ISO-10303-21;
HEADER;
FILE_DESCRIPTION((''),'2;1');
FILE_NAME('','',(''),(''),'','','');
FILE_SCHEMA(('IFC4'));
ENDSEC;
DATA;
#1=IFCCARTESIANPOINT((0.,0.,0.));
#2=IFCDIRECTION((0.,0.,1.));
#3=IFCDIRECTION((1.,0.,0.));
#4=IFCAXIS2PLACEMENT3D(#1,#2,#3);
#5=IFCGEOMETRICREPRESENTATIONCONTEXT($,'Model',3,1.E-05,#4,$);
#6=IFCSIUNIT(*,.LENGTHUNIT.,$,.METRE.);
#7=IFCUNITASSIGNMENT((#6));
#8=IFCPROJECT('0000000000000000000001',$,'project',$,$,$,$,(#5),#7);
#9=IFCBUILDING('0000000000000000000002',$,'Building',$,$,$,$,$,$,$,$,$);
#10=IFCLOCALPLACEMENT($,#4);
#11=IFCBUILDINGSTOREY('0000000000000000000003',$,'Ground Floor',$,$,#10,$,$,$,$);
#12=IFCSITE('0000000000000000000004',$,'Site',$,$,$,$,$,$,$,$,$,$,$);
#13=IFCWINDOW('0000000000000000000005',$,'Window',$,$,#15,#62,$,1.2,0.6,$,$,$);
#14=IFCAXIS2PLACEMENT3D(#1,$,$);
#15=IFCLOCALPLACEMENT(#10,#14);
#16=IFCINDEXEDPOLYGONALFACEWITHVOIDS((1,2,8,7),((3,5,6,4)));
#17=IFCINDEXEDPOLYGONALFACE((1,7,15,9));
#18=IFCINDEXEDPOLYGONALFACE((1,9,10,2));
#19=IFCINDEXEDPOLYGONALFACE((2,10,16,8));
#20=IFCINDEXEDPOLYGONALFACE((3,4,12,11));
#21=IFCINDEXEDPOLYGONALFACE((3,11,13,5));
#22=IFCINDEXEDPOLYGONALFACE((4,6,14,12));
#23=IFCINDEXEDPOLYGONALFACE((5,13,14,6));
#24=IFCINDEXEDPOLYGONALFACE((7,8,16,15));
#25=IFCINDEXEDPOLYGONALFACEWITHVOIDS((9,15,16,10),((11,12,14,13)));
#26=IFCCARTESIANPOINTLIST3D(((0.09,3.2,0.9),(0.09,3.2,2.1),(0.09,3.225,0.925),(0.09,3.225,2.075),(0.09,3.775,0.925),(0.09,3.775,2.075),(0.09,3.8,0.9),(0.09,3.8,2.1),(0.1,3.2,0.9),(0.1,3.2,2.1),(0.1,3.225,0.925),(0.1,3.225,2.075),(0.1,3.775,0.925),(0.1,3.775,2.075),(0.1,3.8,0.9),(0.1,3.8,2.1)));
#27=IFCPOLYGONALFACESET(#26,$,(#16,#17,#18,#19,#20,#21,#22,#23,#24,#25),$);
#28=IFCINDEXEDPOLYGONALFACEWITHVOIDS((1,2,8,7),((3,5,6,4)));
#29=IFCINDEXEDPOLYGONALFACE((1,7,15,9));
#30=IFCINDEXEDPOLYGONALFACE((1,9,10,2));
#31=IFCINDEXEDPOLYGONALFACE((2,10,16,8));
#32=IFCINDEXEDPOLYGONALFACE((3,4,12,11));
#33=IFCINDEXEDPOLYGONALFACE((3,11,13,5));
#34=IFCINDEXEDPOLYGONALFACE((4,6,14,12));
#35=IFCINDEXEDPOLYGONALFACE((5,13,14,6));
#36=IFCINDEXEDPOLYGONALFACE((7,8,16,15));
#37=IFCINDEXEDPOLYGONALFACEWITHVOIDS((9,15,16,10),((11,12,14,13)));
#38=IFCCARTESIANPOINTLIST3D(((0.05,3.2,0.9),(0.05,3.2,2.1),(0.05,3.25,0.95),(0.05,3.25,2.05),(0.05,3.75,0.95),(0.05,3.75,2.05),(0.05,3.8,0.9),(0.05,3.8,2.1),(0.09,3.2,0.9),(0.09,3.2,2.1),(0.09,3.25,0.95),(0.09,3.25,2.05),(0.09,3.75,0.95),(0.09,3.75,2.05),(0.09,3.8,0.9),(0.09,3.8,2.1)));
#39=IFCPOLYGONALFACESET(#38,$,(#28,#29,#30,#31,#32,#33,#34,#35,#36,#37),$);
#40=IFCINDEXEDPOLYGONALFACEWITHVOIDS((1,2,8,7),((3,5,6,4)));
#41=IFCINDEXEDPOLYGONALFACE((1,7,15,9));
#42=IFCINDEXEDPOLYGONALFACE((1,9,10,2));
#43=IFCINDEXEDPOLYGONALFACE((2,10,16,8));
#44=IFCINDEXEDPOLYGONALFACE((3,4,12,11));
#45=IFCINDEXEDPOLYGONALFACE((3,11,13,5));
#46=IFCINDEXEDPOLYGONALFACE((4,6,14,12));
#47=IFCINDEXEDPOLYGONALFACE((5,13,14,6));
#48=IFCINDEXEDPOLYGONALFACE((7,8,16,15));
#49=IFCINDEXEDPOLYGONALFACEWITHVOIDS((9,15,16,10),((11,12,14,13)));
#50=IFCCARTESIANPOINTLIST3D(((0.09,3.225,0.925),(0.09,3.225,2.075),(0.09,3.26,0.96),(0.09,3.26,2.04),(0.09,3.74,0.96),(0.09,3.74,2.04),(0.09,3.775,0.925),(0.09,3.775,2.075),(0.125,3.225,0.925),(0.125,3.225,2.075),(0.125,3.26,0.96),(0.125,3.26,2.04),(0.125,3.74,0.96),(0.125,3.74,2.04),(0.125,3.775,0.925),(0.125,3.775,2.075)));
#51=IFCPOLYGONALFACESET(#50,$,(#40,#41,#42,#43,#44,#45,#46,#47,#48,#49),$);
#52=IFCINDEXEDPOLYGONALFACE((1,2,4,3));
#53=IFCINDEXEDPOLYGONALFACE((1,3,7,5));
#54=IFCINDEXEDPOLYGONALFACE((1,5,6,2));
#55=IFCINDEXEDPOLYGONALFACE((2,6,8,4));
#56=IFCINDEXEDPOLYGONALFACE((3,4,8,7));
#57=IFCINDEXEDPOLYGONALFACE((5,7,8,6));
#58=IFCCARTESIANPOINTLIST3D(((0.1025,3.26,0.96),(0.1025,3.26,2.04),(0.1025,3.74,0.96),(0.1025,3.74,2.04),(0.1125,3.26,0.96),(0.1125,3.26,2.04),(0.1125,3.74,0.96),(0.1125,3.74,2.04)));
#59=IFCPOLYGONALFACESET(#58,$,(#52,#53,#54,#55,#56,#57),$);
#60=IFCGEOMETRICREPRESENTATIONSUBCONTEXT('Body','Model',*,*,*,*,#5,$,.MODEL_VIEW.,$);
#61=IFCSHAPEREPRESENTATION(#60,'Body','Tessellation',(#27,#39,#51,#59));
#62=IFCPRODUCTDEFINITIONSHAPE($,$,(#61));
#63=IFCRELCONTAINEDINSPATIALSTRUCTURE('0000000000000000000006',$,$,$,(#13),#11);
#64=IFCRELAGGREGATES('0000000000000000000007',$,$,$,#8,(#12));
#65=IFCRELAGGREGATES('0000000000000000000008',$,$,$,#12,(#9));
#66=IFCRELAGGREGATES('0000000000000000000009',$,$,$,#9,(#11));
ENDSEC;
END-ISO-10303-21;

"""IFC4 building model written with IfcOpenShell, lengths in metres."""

from ifc_helpers import new_model, si_unit, frame, origin_with_axes, place, context, subcontext, project, spatial, line, indexed_curve, outline, extrude, element, save


model = new_model("IFC4")

# Units and contexts
model_context = context("Model", 3, precision=1e-05, world=origin_with_axes())
body_context = subcontext(model_context, "Body", "Model", "MODEL_VIEW")
ifc_project = project(units=[si_unit("LENGTHUNIT", "METRE")], contexts=[model_context])

# Site, building, storey
site = spatial("IfcSite", under=ifc_project, Name="Site")
building = spatial("IfcBuilding", under=site, Name="Building")
storey_placement = place(None, origin_with_axes())
storey = spatial("IfcBuildingStorey", under=building, at=storey_placement, Name="Ground Floor")

# Window
window_1_placement = place(storey_placement, frame((0.0, 3.8, 0.9), z_axis=(0.0, 0.0, 1.0), x_axis=(0.0, -1.0, 0.0)))
element("IfcWindow", 1, at=window_1_placement, inside=storey, Name="Window", OverallHeight=1.2, OverallWidth=0.6, context=body_context, shape_type="SweptSolid", body=[
    extrude(outline(indexed_curve([(0.0, 0.0), (0.6, 0.0), (0.6, 1.2), (0.0, 1.2)], segments=[line(1, 2, 3, 4, 1)]), holes=[indexed_curve([(0.025, 0.025), (0.575, 0.025), (0.575, 1.175), (0.025, 1.175)], segments=[line(1, 2, 3, 4, 1)])]), frame((0.0, 0.09, 0.0), z_axis=(0.0, -1.0, 0.0), x_axis=(1.0, 0.0, 0.0)), (0.0, 0.0, -1.0), 0.01),
    extrude(outline(indexed_curve([(0.0, 0.0), (0.6, 0.0), (0.6, 1.2), (0.0, 1.2)], segments=[line(1, 2, 3, 4, 1)]), holes=[indexed_curve([(0.05, 0.05), (0.55, 0.05), (0.55, 1.15), (0.05, 1.15)], segments=[line(1, 2, 3, 4, 1)])]), frame((0.0, 0.05, 0.0), z_axis=(0.0, -1.0, 0.0), x_axis=(1.0, 0.0, 0.0)), (0.0, 0.0, -1.0), 0.04),
    extrude(outline(indexed_curve([(0.0, 0.0), (0.55, 0.0), (0.55, 1.15), (0.0, 1.15)], segments=[line(1, 2, 3, 4, 1)]), holes=[indexed_curve([(0.035, 0.035), (0.515, 0.035), (0.515, 1.115), (0.035, 1.115)], segments=[line(1, 2, 3, 4, 1)])]), frame((0.025, 0.09, 0.025), z_axis=(0.0, -1.0, 0.0), x_axis=(1.0, 0.0, 0.0)), (0.0, 0.0, -1.0), 0.035),
    extrude(outline(indexed_curve([(0.035, 0.035), (0.515, 0.035), (0.515, 1.115), (0.035, 1.115)], segments=[line(1, 2, 3, 4, 1)])), frame((0.025, 0.1025, 0.025), z_axis=(0.0, -1.0, 0.0), x_axis=(1.0, 0.0, 0.0)), (0.0, 0.0, -1.0), 0.01),
])

save(model, "model.ifc")
